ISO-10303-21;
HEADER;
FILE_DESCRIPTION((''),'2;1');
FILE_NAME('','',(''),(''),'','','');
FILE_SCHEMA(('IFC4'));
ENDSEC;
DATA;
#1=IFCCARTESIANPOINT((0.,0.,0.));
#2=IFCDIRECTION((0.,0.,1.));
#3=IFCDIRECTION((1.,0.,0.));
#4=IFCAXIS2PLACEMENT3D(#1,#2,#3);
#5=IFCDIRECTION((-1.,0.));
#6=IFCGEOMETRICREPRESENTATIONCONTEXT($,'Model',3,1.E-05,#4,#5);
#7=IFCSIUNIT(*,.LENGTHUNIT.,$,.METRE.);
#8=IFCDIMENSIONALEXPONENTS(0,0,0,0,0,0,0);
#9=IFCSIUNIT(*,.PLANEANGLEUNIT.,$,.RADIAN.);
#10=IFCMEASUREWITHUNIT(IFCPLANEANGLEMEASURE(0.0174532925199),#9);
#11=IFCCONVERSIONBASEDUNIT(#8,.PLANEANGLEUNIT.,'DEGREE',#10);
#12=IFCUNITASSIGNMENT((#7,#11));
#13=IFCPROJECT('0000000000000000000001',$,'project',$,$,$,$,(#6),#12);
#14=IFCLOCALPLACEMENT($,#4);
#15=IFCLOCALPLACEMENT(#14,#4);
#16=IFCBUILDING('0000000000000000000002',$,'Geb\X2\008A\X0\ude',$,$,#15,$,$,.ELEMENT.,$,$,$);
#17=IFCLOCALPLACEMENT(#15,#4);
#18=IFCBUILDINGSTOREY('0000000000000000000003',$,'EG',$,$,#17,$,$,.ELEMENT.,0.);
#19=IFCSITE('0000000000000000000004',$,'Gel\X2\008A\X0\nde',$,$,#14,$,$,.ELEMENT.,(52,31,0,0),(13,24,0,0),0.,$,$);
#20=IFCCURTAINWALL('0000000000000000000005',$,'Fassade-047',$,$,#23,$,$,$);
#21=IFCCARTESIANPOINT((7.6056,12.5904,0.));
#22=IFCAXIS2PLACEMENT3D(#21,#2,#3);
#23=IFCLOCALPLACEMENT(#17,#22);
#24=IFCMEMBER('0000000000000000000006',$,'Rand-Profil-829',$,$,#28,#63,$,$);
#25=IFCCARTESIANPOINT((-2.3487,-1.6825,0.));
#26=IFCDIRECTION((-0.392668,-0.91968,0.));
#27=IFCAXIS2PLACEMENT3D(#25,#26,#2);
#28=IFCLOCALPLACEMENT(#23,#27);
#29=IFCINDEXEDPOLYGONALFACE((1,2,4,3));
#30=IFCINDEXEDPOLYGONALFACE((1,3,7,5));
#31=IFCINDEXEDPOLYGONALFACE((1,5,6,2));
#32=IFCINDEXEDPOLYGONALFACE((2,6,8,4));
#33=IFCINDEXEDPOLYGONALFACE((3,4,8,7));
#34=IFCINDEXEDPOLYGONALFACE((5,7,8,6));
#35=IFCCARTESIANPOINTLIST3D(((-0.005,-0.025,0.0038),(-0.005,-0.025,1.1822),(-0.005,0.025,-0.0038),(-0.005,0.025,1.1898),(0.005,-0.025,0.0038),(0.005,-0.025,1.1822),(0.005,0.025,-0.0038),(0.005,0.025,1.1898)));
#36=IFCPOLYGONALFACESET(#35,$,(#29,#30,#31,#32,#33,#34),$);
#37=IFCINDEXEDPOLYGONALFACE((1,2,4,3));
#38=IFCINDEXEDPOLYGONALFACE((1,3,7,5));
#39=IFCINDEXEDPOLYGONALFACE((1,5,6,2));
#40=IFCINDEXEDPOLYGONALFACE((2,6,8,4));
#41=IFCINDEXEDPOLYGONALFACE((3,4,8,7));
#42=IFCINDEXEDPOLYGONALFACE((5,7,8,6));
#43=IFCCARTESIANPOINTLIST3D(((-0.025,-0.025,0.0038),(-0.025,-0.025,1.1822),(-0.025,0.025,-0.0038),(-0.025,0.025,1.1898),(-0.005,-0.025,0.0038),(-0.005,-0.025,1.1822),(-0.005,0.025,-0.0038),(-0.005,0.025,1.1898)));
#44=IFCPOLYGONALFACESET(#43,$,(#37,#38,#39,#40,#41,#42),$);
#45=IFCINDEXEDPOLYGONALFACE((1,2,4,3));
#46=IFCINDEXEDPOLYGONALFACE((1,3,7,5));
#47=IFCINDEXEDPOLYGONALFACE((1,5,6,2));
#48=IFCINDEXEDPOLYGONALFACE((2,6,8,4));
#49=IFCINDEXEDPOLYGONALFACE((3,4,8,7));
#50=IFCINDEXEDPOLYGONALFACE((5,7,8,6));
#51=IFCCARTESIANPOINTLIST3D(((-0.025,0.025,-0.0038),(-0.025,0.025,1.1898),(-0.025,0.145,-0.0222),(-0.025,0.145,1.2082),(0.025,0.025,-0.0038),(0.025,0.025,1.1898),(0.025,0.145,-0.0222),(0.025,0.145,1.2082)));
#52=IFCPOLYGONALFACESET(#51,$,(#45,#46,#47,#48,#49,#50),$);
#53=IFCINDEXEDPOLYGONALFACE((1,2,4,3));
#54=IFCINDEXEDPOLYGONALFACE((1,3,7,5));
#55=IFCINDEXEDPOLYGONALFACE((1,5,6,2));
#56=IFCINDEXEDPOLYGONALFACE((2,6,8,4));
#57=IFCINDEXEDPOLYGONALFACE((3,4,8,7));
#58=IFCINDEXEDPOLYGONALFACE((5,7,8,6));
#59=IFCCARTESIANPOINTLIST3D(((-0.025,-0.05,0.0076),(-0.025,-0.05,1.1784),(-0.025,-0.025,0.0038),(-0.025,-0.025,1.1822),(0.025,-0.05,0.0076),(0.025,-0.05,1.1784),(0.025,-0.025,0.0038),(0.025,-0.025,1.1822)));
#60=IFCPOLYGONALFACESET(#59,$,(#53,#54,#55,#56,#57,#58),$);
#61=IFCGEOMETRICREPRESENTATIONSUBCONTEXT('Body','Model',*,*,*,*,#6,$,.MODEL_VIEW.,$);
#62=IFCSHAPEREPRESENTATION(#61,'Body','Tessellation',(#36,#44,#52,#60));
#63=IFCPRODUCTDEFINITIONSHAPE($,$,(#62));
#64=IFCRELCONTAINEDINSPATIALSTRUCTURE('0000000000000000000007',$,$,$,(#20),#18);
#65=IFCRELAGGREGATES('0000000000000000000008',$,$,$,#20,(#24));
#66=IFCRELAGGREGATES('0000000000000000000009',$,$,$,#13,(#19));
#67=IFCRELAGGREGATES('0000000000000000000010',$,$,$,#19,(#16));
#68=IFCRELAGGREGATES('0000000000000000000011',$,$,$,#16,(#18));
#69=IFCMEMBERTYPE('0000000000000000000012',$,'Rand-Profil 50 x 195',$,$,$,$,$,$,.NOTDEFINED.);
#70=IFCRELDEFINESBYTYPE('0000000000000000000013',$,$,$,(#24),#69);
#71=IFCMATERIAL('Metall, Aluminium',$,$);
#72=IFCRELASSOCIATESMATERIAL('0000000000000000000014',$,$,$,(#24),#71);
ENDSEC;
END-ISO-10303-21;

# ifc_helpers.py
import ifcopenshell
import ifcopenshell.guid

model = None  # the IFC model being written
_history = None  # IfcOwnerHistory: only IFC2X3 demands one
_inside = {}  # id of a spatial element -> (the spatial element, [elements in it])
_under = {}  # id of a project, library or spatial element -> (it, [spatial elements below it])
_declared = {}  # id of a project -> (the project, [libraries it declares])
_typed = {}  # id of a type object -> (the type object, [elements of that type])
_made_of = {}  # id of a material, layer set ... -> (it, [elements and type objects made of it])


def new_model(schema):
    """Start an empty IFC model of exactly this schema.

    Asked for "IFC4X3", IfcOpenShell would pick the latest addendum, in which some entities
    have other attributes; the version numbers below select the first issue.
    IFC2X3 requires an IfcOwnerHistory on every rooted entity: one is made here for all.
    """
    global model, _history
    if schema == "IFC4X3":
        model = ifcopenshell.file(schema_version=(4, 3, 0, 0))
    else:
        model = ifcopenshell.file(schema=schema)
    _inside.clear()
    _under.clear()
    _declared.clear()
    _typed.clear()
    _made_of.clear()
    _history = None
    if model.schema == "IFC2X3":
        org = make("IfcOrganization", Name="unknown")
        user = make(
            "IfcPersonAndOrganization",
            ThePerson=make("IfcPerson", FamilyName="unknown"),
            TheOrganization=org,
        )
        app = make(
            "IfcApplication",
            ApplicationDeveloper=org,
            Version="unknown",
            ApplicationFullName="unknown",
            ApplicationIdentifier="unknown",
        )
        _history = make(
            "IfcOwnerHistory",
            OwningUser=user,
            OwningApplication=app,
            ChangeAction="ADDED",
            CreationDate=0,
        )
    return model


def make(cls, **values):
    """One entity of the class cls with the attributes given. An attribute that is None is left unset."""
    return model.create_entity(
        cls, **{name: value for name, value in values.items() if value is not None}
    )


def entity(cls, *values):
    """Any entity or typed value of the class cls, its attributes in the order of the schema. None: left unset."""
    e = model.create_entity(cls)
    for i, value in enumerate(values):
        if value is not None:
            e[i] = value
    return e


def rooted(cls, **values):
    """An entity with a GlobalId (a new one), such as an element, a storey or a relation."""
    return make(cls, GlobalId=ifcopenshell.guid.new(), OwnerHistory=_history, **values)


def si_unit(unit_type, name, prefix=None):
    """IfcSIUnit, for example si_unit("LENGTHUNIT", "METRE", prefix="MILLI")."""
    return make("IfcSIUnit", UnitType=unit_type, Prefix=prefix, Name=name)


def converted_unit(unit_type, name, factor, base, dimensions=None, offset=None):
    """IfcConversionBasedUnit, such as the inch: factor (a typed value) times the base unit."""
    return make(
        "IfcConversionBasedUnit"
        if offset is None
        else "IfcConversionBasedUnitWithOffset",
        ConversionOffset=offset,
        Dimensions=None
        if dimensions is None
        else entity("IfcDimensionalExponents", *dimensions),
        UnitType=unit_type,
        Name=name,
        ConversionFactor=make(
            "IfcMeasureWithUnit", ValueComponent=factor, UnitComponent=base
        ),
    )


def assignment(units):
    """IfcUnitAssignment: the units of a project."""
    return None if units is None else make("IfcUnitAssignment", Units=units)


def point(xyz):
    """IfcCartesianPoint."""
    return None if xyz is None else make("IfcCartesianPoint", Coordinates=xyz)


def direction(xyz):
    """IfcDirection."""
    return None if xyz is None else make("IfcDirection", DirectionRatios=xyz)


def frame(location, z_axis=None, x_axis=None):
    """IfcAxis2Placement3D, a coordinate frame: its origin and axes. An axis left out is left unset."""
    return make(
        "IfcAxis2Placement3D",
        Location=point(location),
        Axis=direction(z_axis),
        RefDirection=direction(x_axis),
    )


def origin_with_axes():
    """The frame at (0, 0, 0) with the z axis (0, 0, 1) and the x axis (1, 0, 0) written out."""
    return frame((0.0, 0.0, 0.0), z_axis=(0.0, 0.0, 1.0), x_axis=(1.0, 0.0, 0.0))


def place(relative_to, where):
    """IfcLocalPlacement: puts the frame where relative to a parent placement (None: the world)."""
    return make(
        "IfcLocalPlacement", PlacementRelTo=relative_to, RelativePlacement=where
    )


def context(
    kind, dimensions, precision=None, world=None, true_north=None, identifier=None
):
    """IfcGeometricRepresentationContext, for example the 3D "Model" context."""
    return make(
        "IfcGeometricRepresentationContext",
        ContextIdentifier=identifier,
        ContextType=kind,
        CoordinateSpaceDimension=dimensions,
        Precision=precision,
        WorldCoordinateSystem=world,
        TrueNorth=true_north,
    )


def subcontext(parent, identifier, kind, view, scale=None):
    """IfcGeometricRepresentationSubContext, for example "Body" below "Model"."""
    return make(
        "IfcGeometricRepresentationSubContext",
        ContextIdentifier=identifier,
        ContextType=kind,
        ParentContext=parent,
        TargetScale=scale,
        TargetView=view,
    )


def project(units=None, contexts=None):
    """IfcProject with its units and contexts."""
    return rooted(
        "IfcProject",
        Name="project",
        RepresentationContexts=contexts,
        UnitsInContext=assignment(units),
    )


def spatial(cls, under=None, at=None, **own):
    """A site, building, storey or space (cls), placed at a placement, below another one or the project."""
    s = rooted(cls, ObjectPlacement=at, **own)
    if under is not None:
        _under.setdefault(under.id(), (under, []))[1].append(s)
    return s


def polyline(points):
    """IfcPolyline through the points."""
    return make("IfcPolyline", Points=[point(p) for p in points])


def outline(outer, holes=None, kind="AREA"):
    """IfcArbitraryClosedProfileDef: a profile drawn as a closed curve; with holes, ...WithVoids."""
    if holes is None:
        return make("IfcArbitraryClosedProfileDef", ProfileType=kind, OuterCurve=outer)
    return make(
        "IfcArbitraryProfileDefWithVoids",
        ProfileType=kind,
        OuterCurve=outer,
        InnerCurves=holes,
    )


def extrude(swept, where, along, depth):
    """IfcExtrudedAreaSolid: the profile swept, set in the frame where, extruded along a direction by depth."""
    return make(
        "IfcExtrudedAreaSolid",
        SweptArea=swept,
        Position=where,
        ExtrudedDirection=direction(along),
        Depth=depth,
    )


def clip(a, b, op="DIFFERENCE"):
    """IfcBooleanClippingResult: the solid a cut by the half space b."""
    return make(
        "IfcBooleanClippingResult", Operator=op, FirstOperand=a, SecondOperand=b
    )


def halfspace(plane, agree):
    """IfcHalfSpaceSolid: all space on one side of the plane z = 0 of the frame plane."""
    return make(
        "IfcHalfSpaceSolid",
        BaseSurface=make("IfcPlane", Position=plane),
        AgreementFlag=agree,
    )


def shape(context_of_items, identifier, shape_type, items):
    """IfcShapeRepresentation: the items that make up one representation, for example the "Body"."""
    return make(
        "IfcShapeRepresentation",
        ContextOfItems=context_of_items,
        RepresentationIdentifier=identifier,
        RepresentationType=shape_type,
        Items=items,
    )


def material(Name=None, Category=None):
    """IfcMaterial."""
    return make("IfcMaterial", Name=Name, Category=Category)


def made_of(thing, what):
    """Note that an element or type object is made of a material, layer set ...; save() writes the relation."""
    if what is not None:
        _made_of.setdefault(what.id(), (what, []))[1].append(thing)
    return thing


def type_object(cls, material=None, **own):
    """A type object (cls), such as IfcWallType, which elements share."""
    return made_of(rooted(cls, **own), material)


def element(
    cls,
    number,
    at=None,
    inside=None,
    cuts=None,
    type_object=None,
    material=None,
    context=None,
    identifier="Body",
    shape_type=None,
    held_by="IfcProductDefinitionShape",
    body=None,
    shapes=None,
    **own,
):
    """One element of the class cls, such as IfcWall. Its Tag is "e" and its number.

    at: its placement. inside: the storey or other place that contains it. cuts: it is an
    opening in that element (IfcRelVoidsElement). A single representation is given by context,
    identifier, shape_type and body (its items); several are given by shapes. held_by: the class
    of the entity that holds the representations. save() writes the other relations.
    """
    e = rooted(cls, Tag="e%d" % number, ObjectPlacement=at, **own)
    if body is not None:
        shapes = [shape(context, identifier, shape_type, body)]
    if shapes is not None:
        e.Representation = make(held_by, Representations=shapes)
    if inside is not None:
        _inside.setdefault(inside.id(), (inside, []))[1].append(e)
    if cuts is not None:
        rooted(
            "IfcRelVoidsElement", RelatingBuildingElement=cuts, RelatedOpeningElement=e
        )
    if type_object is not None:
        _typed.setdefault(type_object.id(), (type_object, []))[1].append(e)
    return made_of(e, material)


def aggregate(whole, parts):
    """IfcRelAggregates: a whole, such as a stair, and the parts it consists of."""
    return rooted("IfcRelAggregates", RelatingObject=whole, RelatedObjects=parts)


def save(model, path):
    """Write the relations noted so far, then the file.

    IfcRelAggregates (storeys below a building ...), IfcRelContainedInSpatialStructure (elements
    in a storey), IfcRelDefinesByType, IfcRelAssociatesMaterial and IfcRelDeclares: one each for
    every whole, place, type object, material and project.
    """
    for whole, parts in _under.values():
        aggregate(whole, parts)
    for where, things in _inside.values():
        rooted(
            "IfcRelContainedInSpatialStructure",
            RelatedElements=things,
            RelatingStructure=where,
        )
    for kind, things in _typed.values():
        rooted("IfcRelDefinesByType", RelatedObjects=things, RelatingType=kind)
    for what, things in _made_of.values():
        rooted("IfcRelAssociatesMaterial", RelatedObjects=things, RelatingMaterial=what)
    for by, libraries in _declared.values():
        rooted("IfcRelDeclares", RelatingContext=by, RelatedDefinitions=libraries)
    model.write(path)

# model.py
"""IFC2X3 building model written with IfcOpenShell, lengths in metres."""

from ifc_helpers import new_model, entity, si_unit, converted_unit, direction, frame, origin_with_axes, place, context, subcontext, project, spatial, polyline, outline, extrude, clip, halfspace, material, type_object, element, aggregate, save


model = new_model("IFC2X3")

# Units and contexts
model_context = context("Model", 3, precision=1e-05, world=origin_with_axes(), true_north=direction((-1.0, 0.0)))
body_context = subcontext(model_context, "Body", "Model", "MODEL_VIEW")
ifc_project = project(units=[si_unit("LENGTHUNIT", "METRE"), converted_unit("PLANEANGLEUNIT", "DEGREE", entity("IfcPlaneAngleMeasure", 0.0174532925199), si_unit("PLANEANGLEUNIT", "RADIAN"), dimensions=[0, 0, 0, 0, 0, 0, 0])], contexts=[model_context])

# Site, building, storey
site_placement = place(None, origin_with_axes())
site = spatial("IfcSite", under=ifc_project, at=site_placement, Name="Gel\u008ande", CompositionType="ELEMENT", RefLatitude=(52, 31, 0, 0), RefLongitude=(13, 24, 0, 0), RefElevation=0.0)
building_placement = place(site_placement, origin_with_axes())
building = spatial("IfcBuilding", under=site, at=building_placement, Name="Geb\u008aude", CompositionType="ELEMENT")
storey_placement = place(building_placement, origin_with_axes())
storey = spatial("IfcBuildingStorey", under=building, at=storey_placement, Name="EG", CompositionType="ELEMENT", Elevation=0.0)

# Curtain wall, member
curtain_wall_placement = place(storey_placement, frame((7.6056, 12.5904, 0.0), z_axis=(0.0, 0.0, 1.0), x_axis=(1.0, 0.0, 0.0)))
curtain_wall = element("IfcCurtainWall", 1, at=curtain_wall_placement, inside=storey, Name="Fassade-047")
ifc_material_1 = material(Name="Metall, Aluminium")
member_type_1 = type_object("IfcMemberType", Name="Rand-Profil 50 x 195", PredefinedType="NOTDEFINED")
member_1_placement = place(curtain_wall_placement, frame((-2.3487, -1.6825, 0.0), z_axis=(-0.392668, -0.91968, 0.0), x_axis=(0.0, 0.0, 1.0)))
member_1 = element("IfcMember", 2, at=member_1_placement, type_object=member_type_1, material=ifc_material_1, Name="Rand-Profil-829", context=body_context, shape_type="Clipping", body=[
    clip(clip(extrude(outline(polyline([(0.025, -0.005), (0.025, 0.005), (-0.025, 0.005), (-0.025, -0.005), (0.025, -0.005)])), frame((0.0, 0.0, -0.0038), z_axis=(0.0, 0.0, 1.0), x_axis=(0.0, 1.0, 0.0)), (0.0, 0.0, 1.0), 1.1936), halfspace(frame((0.0, -0.1772, 1.1589), z_axis=(0.0, 0.151179, -0.988506), x_axis=(0.0, -0.988506, -0.151179)), True)), halfspace(frame((0.0, 0.0, 0.0), z_axis=(0.0, 0.151179, 0.988506), x_axis=(0.0, 0.988506, -0.151179)), True)),
    clip(clip(extrude(outline(polyline([(0.025, 0.005), (0.025, 0.025), (-0.025, 0.025), (-0.025, 0.005), (0.025, 0.005)])), frame((0.0, 0.0, -0.0038), z_axis=(0.0, 0.0, 1.0), x_axis=(0.0, 1.0, 0.0)), (0.0, 0.0, 1.0), 1.1936), halfspace(frame((0.0, -0.1772, 1.1589), z_axis=(0.0, 0.151179, -0.988506), x_axis=(0.0, -0.988506, -0.151179)), True)), halfspace(frame((0.0, 0.0, 0.0), z_axis=(0.0, 0.151179, 0.988506), x_axis=(0.0, 0.988506, -0.151179)), True)),
    clip(clip(extrude(outline(polyline([(0.145, -0.025), (0.145, 0.025), (0.025, 0.025), (0.025, -0.025), (0.145, -0.025)])), frame((0.0, 0.0, -0.0222), z_axis=(0.0, 0.0, 1.0), x_axis=(0.0, 1.0, 0.0)), (0.0, 0.0, 1.0), 1.2304), halfspace(frame((0.0, -0.1772, 1.1589), z_axis=(0.0, 0.151179, -0.988506), x_axis=(0.0, -0.988506, -0.151179)), True)), halfspace(frame((0.0, 0.0, 0.0), z_axis=(0.0, 0.151179, 0.988506), x_axis=(0.0, 0.988506, -0.151179)), True)),
    clip(clip(extrude(outline(polyline([(-0.05, 0.025), (-0.05, -0.025), (-0.025, -0.025), (-0.025, 0.025), (-0.05, 0.025)])), frame((0.0, 0.0, 0.0038), z_axis=(0.0, 0.0, 1.0), x_axis=(0.0, 1.0, 0.0)), (0.0, 0.0, 1.0), 1.1784), halfspace(frame((0.0, -0.1772, 1.1589), z_axis=(0.0, 0.151179, -0.988506), x_axis=(0.0, -0.988506, -0.151179)), True)), halfspace(frame((0.0, 0.0, 0.0), z_axis=(0.0, 0.151179, 0.988506), x_axis=(0.0, 0.988506, -0.151179)), True)),
])

aggregate(curtain_wall, [member_1])

save(model, "model.ifc")
